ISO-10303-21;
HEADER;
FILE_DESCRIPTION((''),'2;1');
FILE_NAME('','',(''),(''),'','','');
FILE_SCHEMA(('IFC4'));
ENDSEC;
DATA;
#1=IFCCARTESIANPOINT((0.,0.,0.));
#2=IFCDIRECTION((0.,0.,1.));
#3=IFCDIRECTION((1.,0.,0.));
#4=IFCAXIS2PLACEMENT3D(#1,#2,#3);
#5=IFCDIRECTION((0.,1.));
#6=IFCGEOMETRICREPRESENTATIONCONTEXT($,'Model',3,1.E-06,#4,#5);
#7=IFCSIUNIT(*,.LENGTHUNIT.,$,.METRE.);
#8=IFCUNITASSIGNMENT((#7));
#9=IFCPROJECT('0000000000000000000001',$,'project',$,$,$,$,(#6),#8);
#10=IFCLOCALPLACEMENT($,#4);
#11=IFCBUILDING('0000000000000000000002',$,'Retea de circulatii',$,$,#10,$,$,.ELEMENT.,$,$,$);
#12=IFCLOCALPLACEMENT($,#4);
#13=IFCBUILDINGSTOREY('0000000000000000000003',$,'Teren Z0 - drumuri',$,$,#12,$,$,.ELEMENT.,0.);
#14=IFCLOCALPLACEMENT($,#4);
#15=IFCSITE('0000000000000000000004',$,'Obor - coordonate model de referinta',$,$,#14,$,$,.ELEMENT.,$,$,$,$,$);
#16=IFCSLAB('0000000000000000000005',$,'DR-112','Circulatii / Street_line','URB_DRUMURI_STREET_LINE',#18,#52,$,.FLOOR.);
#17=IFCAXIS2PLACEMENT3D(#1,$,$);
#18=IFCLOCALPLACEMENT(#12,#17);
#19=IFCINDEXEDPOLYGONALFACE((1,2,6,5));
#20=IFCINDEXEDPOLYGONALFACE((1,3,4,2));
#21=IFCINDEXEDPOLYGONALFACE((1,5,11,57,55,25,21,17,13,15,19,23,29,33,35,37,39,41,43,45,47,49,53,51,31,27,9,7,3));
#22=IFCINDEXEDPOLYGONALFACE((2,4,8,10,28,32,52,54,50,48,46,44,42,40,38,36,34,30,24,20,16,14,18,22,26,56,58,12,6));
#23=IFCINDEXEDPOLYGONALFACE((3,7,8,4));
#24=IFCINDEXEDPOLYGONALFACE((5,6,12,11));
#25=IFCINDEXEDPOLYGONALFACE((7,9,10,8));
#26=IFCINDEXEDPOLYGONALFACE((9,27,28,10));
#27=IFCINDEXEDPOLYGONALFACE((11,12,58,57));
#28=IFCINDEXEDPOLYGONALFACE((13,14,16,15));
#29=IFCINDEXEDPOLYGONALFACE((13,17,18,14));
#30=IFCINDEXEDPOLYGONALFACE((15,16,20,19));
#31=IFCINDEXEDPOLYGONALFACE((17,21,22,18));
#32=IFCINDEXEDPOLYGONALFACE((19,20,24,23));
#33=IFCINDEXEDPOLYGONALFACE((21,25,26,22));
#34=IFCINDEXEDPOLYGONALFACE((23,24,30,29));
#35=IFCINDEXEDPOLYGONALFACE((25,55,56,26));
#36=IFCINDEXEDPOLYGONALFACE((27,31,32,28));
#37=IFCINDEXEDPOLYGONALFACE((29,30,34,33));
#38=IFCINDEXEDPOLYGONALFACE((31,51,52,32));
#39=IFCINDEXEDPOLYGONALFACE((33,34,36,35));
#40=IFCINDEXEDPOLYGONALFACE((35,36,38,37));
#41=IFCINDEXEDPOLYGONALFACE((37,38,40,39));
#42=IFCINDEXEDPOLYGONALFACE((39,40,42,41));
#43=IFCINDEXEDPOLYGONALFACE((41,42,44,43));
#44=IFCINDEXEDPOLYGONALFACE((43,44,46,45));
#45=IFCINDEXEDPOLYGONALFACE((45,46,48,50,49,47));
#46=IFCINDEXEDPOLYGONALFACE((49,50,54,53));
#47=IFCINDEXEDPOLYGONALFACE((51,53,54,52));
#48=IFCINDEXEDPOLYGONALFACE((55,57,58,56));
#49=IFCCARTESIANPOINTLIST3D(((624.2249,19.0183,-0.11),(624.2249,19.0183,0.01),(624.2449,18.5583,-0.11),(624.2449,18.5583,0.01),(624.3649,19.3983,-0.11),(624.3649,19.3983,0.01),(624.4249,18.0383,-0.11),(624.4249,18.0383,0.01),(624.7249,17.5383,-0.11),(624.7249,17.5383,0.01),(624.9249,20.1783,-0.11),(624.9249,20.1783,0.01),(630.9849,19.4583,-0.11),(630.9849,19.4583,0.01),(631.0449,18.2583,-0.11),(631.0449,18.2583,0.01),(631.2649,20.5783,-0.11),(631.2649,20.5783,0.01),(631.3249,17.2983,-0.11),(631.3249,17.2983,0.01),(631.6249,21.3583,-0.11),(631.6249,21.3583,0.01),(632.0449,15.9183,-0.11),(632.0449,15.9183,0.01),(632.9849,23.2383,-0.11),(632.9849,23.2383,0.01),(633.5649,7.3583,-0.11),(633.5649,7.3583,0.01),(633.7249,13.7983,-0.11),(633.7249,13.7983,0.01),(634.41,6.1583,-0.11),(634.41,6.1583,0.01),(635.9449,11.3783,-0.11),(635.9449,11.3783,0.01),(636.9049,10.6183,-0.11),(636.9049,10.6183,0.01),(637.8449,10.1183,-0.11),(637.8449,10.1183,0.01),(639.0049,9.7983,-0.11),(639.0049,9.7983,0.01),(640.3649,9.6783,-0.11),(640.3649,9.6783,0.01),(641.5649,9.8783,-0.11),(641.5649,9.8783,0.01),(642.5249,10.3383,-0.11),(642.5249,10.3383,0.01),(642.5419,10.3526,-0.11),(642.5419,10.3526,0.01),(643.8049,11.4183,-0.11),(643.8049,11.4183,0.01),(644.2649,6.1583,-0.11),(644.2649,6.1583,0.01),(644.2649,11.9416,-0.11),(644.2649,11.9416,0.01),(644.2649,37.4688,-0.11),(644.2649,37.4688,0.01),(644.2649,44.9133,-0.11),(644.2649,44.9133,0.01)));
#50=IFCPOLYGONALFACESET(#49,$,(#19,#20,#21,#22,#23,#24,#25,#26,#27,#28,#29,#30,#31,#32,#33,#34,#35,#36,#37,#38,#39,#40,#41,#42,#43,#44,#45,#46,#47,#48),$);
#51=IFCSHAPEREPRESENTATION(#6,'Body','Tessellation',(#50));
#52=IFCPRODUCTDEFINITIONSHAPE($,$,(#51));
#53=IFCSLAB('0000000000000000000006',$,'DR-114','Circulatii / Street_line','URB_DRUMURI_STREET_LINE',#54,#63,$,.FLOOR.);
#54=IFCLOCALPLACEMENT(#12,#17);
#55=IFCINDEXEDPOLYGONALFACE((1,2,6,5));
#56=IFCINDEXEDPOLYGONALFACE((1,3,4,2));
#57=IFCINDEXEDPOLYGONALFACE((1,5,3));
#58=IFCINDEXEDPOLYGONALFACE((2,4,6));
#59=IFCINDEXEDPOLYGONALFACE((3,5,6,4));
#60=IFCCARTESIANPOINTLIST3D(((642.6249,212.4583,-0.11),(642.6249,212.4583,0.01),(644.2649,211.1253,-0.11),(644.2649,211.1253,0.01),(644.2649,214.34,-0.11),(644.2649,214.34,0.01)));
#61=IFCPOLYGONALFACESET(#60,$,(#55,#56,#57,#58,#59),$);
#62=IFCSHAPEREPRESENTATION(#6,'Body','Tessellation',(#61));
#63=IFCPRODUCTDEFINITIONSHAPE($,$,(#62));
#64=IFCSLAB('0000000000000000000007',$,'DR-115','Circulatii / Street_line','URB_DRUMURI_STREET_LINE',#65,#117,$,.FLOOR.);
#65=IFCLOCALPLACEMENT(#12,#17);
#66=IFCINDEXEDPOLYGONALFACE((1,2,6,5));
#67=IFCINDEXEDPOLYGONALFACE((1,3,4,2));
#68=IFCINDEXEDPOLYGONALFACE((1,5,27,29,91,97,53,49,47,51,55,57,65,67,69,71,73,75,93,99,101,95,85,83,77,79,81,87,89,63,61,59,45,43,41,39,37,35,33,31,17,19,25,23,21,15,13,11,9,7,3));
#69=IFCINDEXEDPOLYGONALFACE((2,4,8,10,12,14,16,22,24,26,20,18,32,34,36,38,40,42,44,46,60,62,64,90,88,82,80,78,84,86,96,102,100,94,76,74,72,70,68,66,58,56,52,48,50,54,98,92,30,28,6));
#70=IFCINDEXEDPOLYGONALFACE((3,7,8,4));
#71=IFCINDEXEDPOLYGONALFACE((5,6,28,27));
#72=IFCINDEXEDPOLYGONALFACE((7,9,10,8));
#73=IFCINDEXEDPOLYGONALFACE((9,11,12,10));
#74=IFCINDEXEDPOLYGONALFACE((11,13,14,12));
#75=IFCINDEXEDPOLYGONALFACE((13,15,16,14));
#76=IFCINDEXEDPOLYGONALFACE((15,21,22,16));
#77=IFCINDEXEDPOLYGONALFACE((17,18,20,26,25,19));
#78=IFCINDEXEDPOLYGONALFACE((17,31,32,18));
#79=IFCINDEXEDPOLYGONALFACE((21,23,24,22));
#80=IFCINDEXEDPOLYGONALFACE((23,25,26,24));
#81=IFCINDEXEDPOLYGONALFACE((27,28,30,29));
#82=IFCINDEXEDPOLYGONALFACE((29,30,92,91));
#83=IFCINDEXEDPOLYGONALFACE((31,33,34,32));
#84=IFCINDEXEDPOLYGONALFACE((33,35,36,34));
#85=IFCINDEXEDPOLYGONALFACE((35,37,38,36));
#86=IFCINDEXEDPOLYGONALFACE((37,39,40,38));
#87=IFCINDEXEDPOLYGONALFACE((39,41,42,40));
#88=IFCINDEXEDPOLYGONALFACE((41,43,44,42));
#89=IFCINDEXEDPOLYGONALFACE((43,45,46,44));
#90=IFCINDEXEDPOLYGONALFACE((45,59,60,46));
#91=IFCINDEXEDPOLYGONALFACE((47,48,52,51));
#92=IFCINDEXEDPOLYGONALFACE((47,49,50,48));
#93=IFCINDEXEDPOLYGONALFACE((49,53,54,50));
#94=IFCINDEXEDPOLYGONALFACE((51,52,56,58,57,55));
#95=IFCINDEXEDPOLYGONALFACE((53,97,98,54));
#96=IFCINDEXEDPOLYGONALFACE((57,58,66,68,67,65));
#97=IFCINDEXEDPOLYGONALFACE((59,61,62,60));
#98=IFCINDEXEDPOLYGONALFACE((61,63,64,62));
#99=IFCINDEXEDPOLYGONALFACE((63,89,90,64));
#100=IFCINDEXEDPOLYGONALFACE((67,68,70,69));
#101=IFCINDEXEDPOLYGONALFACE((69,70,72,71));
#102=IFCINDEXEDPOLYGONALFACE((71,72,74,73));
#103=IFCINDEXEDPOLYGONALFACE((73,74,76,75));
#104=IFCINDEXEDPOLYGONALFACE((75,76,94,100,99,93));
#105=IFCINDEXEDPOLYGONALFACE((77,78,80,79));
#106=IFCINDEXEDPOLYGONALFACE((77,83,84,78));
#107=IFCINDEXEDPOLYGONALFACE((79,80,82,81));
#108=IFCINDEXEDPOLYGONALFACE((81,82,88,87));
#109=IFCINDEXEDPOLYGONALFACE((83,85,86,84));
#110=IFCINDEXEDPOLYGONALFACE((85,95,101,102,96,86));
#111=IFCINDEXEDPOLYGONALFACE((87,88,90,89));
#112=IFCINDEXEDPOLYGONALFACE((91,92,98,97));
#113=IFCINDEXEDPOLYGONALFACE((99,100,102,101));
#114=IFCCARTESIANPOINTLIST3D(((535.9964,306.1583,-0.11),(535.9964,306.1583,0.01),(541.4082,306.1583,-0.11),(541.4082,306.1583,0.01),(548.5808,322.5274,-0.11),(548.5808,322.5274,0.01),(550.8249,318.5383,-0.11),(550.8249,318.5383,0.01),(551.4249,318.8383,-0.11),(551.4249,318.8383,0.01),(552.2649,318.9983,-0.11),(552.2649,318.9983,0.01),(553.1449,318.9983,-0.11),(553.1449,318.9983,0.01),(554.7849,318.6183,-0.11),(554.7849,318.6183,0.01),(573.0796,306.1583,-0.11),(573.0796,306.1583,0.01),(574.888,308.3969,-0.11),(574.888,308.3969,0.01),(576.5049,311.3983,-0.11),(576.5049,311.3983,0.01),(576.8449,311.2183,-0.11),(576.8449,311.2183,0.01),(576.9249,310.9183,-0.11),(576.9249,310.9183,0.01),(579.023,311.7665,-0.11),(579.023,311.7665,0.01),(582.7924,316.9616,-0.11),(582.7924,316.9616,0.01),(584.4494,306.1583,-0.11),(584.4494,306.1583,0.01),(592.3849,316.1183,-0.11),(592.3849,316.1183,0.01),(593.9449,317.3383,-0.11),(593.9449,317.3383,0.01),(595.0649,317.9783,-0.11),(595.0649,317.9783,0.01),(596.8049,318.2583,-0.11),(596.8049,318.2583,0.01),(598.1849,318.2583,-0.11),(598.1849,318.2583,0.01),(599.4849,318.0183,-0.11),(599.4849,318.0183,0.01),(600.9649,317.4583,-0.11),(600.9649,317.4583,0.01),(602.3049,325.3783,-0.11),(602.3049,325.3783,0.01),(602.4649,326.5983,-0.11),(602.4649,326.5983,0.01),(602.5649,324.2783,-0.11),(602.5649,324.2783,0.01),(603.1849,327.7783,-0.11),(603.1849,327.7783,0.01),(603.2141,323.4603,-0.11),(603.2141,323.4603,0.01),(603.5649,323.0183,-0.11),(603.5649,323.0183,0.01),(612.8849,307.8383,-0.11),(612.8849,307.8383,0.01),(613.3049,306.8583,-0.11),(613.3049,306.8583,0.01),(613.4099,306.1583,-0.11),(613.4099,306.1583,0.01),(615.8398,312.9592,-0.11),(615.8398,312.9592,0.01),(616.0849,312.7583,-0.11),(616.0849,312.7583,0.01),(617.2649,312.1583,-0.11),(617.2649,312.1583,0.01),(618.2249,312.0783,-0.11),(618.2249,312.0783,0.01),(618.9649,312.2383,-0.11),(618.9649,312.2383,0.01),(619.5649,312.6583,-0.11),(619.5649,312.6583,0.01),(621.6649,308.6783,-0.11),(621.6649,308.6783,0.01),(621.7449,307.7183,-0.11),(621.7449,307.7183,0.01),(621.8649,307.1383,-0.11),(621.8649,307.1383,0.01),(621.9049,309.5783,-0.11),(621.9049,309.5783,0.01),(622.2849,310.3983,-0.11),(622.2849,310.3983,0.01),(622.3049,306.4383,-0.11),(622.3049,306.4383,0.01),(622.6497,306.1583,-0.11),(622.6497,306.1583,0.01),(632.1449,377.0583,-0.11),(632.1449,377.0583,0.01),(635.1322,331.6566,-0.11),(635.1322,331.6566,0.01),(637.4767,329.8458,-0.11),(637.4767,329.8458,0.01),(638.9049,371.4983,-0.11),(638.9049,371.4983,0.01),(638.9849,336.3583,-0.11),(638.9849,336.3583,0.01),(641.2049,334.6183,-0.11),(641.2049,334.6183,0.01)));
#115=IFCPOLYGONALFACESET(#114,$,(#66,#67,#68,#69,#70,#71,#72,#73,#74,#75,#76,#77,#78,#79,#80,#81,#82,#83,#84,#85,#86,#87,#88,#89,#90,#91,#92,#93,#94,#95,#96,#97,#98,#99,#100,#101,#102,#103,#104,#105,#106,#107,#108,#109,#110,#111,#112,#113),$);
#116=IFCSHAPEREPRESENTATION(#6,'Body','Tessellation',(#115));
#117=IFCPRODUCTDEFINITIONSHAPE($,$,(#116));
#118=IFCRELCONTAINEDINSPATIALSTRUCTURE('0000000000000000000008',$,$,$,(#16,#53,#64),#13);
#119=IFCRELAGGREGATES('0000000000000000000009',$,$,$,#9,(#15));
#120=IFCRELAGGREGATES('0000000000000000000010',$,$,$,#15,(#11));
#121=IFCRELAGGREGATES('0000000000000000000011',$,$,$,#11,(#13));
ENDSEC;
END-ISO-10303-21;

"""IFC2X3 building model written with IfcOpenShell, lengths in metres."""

from ifc_helpers import new_model, si_unit, direction, frame, origin_with_axes, place, context, project, spatial, polyline, outline, extrude, element, save


model = new_model("IFC2X3")

# Units and contexts
model_context = context("Model", 3, precision=1e-06, world=origin_with_axes(), true_north=direction((0.0, 1.0)))
ifc_project = project(units=[si_unit("LENGTHUNIT", "METRE")], contexts=[model_context])

# Site, building, storey
site_placement = place(None, origin_with_axes())
site = spatial("IfcSite", under=ifc_project, at=site_placement, Name="Obor - coordonate model de referinta", CompositionType="ELEMENT")
building_placement = place(None, origin_with_axes())
building = spatial("IfcBuilding", under=site, at=building_placement, Name="Retea de circulatii", CompositionType="ELEMENT")
storey_placement = place(None, origin_with_axes())
storey = spatial("IfcBuildingStorey", under=building, at=storey_placement, Name="Teren Z0 - drumuri", CompositionType="ELEMENT", Elevation=0.0)

# Slabs
slab_1_placement = place(None, origin_with_axes())
element("IfcSlab", 1, at=slab_1_placement, inside=storey, Name="DR-112", Description="Circulatii / Street_line", ObjectType="URB_DRUMURI_STREET_LINE", PredefinedType="FLOOR", context=model_context, shape_type="SweptSolid", body=[
    extrude(outline(polyline([(631.6249, 21.3583), (632.9849, 23.2383), (644.2649, 37.4688), (644.2649, 44.9133), (624.9249, 20.1783), (624.3649, 19.3983), (624.2249, 19.0183), (624.2449, 18.5583), (624.4249, 18.0383), (624.7249, 17.5383), (633.5649, 7.3583), (634.41, 6.1583), (644.2649, 6.1583), (644.2649, 11.9416), (643.8049, 11.4183), (642.5419, 10.3526), (642.5249, 10.3383), (641.5649, 9.8783), (640.3649, 9.6783), (639.0049, 9.7983), (637.8449, 10.1183), (636.9049, 10.6183), (635.9449, 11.3783), (633.7249, 13.7983), (632.0449, 15.9183), (631.3249, 17.2983), (631.0449, 18.2583), (630.9849, 19.4583), (631.2649, 20.5783), (631.6249, 21.3583)])), frame((0.0, 0.0, -0.11), z_axis=(0.0, 0.0, 1.0), x_axis=(1.0, 0.0, 0.0)), (0.0, 0.0, 1.0), 0.12),
])
slab_2_placement = place(None, origin_with_axes())
element("IfcSlab", 2, at=slab_2_placement, inside=storey, Name="DR-114", Description="Circulatii / Street_line", ObjectType="URB_DRUMURI_STREET_LINE", PredefinedType="FLOOR", context=model_context, shape_type="SweptSolid", body=[
    extrude(outline(polyline([(644.2649, 211.1253), (644.2649, 214.34), (642.6249, 212.4583), (644.2649, 211.1253)])), frame((0.0, 0.0, -0.11), z_axis=(0.0, 0.0, 1.0), x_axis=(1.0, 0.0, 0.0)), (0.0, 0.0, 1.0), 0.12),
])
slab_3_placement = place(None, origin_with_axes())
element("IfcSlab", 3, at=slab_3_placement, inside=storey, Name="DR-115", Description="Circulatii / Street_line", ObjectType="URB_DRUMURI_STREET_LINE", PredefinedType="FLOOR", context=model_context, shape_type="SweptSolid", body=[
    extrude(outline(polyline([(612.8849, 307.8383), (613.3049, 306.8583), (613.4099, 306.1583), (622.6497, 306.1583), (622.3049, 306.4383), (621.8649, 307.1383), (621.7449, 307.7183), (621.6649, 308.6783), (621.9049, 309.5783), (622.2849, 310.3983), (637.4767, 329.8458), (641.2049, 334.6183), (638.9849, 336.3583), (635.1322, 331.6566), (619.5649, 312.6583), (618.9649, 312.2383), (618.2249, 312.0783), (617.2649, 312.1583), (616.0849, 312.7583), (615.8398, 312.9592), (603.5649, 323.0183), (603.2141, 323.4603), (602.5649, 324.2783), (602.3049, 325.3783), (602.4649, 326.5983), (603.1849, 327.7783), (638.9049, 371.4983), (632.1449, 377.0583), (582.7924, 316.9616), (579.023, 311.7665), (548.5808, 322.5274), (535.9964, 306.1583), (541.4082, 306.1583), (550.8249, 318.5383), (551.4249, 318.8383), (552.2649, 318.9983), (553.1449, 318.9983), (554.7849, 318.6183), (576.5049, 311.3983), (576.8449, 311.2183), (576.9249, 310.9183), (574.888, 308.3969), (573.0796, 306.1583), (584.4494, 306.1583), (592.3849, 316.1183), (593.9449, 317.3383), (595.0649, 317.9783), (596.8049, 318.2583), (598.1849, 318.2583), (599.4849, 318.0183), (600.9649, 317.4583), (612.8849, 307.8383)])), frame((0.0, 0.0, -0.11), z_axis=(0.0, 0.0, 1.0), x_axis=(1.0, 0.0, 0.0)), (0.0, 0.0, 1.0), 0.12),
])

save(model, "model.ifc")
